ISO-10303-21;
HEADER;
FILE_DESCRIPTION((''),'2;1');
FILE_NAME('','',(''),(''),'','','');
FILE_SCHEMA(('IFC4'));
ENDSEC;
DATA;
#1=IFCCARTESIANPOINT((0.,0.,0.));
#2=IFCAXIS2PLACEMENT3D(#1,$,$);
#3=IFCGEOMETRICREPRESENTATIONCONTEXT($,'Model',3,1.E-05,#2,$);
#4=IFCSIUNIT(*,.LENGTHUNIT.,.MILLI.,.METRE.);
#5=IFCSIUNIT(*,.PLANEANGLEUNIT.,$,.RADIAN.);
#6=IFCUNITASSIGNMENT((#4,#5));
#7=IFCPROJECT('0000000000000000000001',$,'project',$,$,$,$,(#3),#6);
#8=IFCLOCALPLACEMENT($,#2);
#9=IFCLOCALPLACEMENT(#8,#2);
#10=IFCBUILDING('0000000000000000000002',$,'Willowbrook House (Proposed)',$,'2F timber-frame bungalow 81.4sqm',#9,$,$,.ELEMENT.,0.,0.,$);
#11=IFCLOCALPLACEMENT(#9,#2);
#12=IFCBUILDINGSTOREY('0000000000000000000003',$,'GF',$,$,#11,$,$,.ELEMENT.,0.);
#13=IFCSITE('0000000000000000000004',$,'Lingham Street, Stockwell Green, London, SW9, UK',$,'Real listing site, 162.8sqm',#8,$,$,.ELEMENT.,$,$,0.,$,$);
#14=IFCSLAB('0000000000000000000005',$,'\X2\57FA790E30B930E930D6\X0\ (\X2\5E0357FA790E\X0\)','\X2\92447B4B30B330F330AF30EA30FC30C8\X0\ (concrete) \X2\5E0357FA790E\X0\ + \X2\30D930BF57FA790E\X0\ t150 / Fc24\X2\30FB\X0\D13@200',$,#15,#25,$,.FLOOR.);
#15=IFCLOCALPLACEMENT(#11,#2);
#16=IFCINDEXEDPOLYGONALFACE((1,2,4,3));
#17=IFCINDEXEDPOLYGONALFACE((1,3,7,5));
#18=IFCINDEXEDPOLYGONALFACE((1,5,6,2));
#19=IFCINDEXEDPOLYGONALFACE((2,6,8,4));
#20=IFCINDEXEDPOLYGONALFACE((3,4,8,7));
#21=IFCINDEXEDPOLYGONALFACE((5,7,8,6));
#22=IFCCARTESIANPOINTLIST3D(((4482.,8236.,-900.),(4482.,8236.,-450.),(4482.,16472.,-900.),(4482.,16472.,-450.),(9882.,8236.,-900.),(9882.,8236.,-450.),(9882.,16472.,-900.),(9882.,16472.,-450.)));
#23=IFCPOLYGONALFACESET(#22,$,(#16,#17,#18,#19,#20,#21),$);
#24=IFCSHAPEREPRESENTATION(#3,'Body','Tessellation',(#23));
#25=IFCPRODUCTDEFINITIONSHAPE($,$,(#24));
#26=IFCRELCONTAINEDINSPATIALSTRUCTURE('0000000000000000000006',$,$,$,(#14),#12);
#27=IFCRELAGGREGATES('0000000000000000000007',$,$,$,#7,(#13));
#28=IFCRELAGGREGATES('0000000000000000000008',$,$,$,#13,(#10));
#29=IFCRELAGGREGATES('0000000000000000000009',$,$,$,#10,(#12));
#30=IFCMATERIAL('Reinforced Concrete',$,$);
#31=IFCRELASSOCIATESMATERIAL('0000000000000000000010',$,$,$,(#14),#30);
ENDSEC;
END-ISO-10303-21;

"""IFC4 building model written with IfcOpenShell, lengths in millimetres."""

from ifc_helpers import new_model, si_unit, frame, frame_2d, origin, place, context, project, spatial, rectangle, extrude, material, element, save


model = new_model("IFC4")

# Units and contexts
model_context = context("Model", 3, precision=1e-05, world=origin())
ifc_project = project(units=[si_unit("LENGTHUNIT", "METRE", prefix="MILLI"), si_unit("PLANEANGLEUNIT", "RADIAN")], contexts=[model_context])

# Site, building, storey
site_placement = place(None, origin())
site = spatial("IfcSite", under=ifc_project, at=site_placement, Name="Lingham Street, Stockwell Green, London, SW9, UK", ObjectType="Real listing site, 162.8sqm", CompositionType="ELEMENT", RefElevation=0.0)
building_placement = place(site_placement, origin())
building = spatial("IfcBuilding", under=site, at=building_placement, Name="Willowbrook House (Proposed)", ObjectType="2F timber-frame bungalow 81.4sqm", CompositionType="ELEMENT", ElevationOfRefHeight=0.0, ElevationOfTerrain=0.0)
storey_placement = place(building_placement, origin())
storey = spatial("IfcBuildingStorey", under=building, at=storey_placement, Name="GF", CompositionType="ELEMENT", Elevation=0.0)

# Slab
ifc_material_1 = material(Name="Reinforced Concrete")
slab_1_placement = place(storey_placement, frame((2241.0, 4118.0, -450.0)))
element("IfcSlab", 1, at=slab_1_placement, inside=storey, material=ifc_material_1, Name="基礎スラブ (布基礎)", Description="鉄筋コンクリート (concrete) 布基礎 + ベタ基礎 t150 / Fc24・D13@200", PredefinedType="FLOOR", context=model_context, shape_type="SweptSolid", body=[
    extrude(rectangle(XDim=5400.0, YDim=8236.0, at=frame_2d((2700.0, 4118.0))), frame((2241.0, 4118.0, -450.0)), (0.0, 0.0, 1.0), 450.0),
])

save(model, "model.ifc")
